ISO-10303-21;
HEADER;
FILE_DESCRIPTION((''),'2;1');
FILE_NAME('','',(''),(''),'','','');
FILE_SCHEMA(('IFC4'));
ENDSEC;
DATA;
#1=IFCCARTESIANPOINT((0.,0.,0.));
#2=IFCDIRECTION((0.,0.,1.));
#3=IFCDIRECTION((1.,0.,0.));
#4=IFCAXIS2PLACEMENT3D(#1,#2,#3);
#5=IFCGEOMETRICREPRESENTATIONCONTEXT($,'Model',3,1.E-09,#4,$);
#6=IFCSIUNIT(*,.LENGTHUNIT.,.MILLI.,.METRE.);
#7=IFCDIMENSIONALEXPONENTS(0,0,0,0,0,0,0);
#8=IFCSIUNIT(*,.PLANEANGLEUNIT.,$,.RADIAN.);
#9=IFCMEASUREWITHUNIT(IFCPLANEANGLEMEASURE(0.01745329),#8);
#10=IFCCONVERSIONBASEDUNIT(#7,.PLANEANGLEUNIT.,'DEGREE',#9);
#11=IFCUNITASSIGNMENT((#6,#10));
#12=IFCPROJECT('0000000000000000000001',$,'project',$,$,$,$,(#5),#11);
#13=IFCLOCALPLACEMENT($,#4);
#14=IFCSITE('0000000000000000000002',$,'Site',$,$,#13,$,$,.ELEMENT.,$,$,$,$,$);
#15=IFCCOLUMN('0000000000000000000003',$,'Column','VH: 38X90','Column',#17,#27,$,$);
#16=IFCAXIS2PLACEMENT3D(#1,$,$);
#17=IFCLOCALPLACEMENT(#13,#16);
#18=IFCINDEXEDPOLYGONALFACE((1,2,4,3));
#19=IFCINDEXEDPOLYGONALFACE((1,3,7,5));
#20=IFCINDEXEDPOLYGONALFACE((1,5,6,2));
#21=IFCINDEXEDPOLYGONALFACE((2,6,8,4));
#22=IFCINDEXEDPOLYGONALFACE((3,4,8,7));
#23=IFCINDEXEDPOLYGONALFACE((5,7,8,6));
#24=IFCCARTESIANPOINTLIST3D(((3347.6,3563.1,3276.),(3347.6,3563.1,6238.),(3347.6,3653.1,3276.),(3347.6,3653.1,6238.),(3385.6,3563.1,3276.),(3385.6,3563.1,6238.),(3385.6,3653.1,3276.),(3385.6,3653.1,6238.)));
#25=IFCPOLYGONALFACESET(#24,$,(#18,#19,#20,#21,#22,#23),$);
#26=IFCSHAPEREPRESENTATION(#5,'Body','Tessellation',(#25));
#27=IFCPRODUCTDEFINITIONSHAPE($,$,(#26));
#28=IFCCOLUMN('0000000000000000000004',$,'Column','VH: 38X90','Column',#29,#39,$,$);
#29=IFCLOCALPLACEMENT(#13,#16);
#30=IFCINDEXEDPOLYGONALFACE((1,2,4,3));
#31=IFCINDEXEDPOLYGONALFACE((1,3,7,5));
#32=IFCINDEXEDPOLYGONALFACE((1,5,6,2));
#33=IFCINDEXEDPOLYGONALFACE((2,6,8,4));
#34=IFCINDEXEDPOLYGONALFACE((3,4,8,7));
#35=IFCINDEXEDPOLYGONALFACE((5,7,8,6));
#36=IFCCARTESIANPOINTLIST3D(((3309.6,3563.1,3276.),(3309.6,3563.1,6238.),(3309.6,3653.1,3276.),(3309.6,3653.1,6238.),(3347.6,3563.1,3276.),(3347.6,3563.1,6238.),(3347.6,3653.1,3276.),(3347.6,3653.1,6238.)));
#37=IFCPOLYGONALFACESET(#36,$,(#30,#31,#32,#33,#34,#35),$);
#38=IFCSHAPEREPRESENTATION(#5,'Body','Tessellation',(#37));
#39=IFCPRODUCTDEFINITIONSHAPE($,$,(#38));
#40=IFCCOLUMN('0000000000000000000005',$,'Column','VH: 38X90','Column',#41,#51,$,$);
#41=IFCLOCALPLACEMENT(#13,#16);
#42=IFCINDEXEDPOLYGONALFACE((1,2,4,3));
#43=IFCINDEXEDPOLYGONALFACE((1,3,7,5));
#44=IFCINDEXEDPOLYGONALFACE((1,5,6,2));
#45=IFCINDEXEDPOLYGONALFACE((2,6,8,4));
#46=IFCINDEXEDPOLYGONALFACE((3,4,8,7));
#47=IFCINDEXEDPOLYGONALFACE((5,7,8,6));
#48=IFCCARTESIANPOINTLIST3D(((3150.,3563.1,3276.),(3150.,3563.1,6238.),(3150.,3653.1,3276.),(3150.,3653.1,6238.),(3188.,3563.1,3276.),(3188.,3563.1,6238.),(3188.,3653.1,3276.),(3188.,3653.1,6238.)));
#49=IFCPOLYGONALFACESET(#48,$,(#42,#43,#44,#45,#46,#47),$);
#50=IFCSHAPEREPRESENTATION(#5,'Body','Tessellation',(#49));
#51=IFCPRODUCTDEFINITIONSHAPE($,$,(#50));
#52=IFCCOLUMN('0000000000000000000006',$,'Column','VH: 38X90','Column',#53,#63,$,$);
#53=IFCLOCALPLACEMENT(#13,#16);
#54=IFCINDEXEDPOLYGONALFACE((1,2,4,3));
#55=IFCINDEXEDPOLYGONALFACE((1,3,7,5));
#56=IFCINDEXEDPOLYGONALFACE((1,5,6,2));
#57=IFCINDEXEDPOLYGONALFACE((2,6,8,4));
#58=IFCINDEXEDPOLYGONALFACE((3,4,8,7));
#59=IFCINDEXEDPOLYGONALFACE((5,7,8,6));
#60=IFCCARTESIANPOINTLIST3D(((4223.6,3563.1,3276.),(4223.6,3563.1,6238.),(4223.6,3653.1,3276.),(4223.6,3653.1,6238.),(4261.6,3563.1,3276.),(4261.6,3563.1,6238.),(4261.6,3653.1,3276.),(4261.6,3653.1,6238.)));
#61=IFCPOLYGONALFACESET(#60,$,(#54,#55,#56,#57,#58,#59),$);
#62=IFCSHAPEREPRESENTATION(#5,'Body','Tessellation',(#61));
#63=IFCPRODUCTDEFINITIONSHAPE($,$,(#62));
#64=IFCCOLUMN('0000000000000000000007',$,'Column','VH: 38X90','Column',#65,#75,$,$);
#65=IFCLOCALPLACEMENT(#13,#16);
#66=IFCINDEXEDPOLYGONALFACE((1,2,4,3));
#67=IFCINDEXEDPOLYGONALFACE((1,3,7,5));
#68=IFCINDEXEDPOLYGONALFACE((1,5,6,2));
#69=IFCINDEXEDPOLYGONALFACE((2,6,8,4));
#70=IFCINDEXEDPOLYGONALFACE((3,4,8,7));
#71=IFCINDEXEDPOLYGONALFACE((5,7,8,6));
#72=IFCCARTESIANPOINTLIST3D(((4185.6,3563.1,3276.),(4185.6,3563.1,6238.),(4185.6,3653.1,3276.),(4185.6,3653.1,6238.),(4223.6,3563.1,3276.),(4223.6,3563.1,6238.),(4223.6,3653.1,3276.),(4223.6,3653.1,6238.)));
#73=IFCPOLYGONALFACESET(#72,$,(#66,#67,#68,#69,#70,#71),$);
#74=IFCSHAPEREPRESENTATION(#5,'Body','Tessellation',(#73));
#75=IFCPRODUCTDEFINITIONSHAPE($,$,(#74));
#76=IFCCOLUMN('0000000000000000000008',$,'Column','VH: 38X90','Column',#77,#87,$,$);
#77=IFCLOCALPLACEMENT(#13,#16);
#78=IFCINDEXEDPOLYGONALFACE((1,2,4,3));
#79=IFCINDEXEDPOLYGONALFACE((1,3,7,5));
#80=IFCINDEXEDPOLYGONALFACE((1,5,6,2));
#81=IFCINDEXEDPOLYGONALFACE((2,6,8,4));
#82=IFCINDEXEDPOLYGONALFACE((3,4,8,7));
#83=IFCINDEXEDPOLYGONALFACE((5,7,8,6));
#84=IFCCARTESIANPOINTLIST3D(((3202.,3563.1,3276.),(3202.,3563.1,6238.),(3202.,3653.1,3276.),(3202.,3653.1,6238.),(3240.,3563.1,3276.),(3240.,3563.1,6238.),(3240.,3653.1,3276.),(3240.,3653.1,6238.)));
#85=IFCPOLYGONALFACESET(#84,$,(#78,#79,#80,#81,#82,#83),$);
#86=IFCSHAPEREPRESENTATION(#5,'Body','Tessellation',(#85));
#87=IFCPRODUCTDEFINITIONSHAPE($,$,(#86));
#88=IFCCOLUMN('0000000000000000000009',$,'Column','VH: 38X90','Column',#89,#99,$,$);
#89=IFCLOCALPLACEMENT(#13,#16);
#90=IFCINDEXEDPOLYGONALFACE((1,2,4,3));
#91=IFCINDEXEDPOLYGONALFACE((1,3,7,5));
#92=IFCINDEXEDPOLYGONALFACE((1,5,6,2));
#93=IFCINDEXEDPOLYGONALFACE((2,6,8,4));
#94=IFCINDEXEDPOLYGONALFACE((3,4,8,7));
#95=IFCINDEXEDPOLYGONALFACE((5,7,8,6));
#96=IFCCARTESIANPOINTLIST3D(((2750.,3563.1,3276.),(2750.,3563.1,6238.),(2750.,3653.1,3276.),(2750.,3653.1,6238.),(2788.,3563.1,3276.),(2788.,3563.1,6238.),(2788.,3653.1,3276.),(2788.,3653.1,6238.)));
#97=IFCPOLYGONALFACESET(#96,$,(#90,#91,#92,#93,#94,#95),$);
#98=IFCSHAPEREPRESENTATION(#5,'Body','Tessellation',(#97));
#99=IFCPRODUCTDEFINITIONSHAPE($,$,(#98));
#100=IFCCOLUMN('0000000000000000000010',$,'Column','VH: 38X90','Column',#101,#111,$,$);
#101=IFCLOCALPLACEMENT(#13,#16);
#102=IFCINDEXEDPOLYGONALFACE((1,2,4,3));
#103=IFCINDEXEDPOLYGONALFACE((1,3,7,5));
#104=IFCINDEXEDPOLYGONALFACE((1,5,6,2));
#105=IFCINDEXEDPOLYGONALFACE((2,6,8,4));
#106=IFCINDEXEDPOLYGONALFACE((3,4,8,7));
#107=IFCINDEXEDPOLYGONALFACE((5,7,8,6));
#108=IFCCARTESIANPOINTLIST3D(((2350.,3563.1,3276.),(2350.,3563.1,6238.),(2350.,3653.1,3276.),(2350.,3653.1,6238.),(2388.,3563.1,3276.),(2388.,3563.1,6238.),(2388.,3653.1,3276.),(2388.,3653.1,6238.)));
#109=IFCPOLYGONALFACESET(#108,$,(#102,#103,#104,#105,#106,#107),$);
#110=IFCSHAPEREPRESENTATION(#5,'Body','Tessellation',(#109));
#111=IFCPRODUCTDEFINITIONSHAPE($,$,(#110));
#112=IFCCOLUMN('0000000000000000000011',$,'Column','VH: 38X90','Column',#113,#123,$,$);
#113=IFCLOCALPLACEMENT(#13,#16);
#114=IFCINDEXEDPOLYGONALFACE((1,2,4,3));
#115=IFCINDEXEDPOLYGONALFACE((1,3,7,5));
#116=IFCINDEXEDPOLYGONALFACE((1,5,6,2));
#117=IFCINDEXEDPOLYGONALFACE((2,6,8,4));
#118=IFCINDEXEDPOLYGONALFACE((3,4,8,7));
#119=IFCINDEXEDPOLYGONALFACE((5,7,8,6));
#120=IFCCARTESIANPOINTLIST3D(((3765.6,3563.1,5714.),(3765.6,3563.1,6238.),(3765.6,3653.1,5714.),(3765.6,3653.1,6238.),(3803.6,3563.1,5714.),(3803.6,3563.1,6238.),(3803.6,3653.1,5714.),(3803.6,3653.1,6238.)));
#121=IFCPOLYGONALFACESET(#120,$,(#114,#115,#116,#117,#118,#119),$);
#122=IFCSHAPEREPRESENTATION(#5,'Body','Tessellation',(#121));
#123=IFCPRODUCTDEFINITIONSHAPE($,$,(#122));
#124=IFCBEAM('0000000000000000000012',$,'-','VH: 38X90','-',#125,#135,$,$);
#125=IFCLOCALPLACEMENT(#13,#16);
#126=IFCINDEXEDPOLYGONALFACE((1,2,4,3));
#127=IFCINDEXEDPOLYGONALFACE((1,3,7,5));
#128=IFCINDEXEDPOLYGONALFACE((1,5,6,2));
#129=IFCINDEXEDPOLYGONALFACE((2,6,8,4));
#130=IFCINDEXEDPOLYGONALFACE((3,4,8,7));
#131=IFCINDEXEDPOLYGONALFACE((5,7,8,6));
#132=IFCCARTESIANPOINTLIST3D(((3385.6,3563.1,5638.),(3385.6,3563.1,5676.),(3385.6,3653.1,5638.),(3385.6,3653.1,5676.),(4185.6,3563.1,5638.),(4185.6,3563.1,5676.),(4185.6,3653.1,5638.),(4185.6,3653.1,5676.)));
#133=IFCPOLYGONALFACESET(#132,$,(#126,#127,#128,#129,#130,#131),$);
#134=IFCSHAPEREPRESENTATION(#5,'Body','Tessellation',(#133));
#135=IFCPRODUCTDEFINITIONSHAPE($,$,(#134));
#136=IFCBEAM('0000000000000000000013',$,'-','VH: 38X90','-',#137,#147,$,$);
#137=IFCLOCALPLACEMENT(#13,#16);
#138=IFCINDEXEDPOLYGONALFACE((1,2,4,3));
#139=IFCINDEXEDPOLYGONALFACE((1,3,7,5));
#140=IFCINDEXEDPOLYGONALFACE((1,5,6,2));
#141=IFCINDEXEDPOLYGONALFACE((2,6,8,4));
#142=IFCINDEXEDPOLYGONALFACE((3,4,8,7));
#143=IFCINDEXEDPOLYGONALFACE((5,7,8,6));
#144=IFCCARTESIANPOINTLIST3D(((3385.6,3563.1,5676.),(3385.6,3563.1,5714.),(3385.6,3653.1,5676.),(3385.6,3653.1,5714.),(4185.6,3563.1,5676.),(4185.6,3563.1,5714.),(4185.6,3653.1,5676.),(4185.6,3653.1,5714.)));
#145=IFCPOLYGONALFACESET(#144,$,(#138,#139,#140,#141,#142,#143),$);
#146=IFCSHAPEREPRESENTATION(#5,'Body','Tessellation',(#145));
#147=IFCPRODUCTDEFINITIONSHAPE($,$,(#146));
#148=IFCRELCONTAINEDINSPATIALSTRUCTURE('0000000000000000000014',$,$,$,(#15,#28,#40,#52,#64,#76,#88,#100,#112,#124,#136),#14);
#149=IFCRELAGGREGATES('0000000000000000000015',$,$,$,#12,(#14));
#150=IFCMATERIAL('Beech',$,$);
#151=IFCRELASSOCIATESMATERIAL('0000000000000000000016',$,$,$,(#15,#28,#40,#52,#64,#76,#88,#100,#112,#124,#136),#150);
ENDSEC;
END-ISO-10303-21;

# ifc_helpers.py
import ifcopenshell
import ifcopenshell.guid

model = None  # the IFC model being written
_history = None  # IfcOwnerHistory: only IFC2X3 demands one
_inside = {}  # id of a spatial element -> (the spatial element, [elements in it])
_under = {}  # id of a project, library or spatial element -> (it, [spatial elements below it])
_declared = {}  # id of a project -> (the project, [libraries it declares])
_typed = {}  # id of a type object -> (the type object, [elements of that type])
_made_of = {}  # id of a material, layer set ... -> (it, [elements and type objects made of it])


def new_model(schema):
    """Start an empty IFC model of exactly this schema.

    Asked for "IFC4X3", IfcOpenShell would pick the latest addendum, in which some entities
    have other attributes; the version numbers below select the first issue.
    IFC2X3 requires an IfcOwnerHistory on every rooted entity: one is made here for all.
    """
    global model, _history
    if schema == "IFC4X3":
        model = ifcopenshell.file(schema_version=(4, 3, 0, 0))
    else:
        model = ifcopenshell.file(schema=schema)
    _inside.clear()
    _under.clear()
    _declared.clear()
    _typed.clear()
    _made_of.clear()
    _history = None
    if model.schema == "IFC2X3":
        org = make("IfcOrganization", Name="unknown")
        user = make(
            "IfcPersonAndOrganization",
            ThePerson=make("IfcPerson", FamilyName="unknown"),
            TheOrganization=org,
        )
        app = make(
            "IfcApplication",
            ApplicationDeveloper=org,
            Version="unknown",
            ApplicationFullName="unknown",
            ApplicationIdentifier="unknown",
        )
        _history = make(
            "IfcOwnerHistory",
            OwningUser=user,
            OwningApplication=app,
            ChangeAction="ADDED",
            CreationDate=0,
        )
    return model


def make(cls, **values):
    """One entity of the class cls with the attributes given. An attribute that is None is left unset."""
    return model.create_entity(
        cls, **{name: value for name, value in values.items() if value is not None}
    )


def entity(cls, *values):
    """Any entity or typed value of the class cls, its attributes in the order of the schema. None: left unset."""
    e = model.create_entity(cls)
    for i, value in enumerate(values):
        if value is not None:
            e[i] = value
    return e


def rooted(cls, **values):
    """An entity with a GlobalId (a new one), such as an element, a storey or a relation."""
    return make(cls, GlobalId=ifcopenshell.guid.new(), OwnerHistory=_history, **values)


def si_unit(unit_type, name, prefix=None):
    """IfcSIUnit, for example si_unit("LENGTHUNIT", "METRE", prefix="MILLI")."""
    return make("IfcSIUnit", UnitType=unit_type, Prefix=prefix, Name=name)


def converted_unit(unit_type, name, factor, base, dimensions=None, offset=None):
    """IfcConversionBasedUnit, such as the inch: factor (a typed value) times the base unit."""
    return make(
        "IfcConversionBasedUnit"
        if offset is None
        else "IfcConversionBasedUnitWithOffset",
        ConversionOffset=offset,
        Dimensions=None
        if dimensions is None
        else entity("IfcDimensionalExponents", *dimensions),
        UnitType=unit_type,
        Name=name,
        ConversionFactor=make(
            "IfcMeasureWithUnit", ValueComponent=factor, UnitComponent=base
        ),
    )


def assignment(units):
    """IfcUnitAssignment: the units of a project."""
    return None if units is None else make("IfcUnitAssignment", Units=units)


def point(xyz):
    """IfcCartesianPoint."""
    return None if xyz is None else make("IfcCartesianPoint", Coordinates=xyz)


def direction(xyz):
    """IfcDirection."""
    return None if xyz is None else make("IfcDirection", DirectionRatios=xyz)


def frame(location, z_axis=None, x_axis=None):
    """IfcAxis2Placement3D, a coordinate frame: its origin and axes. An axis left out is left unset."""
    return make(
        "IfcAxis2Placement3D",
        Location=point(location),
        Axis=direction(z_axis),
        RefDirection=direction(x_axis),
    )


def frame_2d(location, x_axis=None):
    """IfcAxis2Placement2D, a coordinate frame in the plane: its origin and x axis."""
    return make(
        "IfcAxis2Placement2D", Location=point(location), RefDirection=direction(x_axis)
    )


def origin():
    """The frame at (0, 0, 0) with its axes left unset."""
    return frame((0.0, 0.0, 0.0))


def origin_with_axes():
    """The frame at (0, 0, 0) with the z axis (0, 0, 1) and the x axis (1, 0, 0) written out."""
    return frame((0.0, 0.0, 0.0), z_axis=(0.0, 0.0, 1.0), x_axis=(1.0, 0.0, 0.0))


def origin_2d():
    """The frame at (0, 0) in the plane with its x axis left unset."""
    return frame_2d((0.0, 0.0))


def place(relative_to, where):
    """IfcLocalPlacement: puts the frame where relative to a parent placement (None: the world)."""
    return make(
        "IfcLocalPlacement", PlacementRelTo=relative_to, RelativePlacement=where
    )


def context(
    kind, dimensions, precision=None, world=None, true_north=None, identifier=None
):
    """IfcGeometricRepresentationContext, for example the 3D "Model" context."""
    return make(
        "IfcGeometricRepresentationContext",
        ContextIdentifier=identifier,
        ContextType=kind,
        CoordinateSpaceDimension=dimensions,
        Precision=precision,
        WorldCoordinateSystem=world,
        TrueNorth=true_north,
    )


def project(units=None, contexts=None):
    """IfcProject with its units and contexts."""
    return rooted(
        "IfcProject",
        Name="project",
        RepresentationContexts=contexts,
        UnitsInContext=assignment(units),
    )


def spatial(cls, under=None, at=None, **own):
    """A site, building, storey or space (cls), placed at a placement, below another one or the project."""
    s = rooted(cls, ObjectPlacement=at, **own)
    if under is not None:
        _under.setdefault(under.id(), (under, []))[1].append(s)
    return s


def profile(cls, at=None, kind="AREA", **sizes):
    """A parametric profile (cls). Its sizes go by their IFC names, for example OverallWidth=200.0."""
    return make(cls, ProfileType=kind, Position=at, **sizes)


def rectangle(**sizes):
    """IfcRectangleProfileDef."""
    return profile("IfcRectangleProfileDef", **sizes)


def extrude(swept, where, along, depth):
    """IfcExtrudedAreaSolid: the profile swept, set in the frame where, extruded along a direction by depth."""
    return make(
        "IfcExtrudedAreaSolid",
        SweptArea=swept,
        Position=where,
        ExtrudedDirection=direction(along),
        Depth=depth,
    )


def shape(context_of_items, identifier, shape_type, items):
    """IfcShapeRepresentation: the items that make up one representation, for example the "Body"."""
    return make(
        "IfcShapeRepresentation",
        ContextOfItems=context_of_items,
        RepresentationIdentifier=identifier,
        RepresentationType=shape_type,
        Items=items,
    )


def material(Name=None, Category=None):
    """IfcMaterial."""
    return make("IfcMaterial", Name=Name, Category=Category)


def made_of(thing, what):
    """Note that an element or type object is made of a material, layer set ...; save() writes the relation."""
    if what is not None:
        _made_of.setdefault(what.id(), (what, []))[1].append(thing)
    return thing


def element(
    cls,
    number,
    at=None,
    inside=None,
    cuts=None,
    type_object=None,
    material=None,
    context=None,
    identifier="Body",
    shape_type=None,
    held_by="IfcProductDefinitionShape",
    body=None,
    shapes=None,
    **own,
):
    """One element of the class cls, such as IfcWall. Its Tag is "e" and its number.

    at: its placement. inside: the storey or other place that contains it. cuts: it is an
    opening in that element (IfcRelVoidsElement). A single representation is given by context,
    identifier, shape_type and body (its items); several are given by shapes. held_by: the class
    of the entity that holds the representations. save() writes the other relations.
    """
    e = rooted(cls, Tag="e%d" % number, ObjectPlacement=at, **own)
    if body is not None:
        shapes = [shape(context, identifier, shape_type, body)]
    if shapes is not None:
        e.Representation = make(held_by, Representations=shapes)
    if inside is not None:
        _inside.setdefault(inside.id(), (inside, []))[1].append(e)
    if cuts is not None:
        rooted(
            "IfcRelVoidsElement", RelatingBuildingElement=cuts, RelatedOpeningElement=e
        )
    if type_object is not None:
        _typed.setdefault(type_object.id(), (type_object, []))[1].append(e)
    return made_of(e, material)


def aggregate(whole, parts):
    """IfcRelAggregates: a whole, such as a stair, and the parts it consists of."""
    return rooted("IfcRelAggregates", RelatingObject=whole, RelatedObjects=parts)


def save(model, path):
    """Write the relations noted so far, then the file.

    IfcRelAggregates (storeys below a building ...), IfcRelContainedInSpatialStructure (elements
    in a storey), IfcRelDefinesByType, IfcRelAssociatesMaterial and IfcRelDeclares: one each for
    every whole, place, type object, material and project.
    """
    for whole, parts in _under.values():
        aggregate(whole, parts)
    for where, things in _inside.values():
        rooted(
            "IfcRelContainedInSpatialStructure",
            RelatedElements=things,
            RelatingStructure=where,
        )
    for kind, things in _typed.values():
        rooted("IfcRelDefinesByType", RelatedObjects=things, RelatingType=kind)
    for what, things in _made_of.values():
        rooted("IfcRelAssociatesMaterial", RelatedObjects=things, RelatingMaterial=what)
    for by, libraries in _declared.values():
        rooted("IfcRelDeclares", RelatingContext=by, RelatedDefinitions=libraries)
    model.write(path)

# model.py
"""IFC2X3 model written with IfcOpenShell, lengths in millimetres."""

from ifc_helpers import new_model, entity, si_unit, converted_unit, frame, origin, origin_with_axes, origin_2d, place, context, project, spatial, rectangle, extrude, material, element, save


model = new_model("IFC2X3")

# Units and contexts
model_context = context("Model", 3, precision=1e-09, world=origin_with_axes())
ifc_project = project(units=[si_unit("LENGTHUNIT", "METRE", prefix="MILLI"), converted_unit("PLANEANGLEUNIT", "DEGREE", entity("IfcPlaneAngleMeasure", 0.01745329), si_unit("PLANEANGLEUNIT", "RADIAN"), dimensions=[0, 0, 0, 0, 0, 0, 0])], contexts=[model_context])

# Site
site_placement = place(None, origin_with_axes())
site = spatial("IfcSite", under=ifc_project, at=site_placement, Name="Site", CompositionType="ELEMENT")

# Columns
ifc_material = material(Name="Beech")
for number, where, z_axis, x_axis, name in (
    (1, (3366.6, 3608.1, 3276.0), (0.0, 0.0, -1.0), (-1.0, 0.0, 0.0), "Column"),
    (2, (3328.6, 3608.1, 3276.0), (0.0, 0.0, -1.0), (-1.0, 0.0, 0.0), "Column"),
    (3, (3169.0, 3608.1, 3276.0), (0.0, 0.0, -1.0), (-1.0, 0.0, 0.0), "Column"),
    (4, (4242.6, 3608.1, 3276.0), (0.0, 0.0, -1.0), (-1.0, 0.0, 0.0), "Column"),
    (5, (4204.6, 3608.1, 3276.0), (0.0, 0.0, -1.0), (-1.0, 0.0, 0.0), "Column"),
    (6, (3221.0, 3608.1, 3276.0), (0.0, 0.0, -1.0), (-1.0, 0.0, 0.0), "Column"),
    (7, (2769.0, 3608.1, 3276.0), (0.0, 0.0, -1.0), (-1.0, 0.0, 0.0), "Column"),
    (8, (2369.0, 3608.1, 3276.0), (0.0, 0.0, -1.0), (-1.0, 0.0, 0.0), "Column"),
):
    element("IfcColumn", number, at=place(None, frame(where, z_axis=z_axis, x_axis=x_axis)), inside=site, material=ifc_material, Name=name, Description="VH: 38X90", ObjectType="Column", context=model_context, shape_type="SweptSolid", body=[
        extrude(rectangle(XDim=38.0, YDim=90.0, at=origin_2d()), origin(), (0.0, 0.0, -1.0), 2962.0),
    ])
column_placement = place(None, frame((3784.6, 3608.1, 5714.0), z_axis=(0.0, 0.0, -1.0), x_axis=(-1.0, 0.0, 0.0)))
element("IfcColumn", 9, at=column_placement, inside=site, material=ifc_material, Name="Column", Description="VH: 38X90", ObjectType="Column", context=model_context, shape_type="SweptSolid", body=[
    extrude(rectangle(XDim=38.0, YDim=90.0, at=origin_2d()), origin(), (0.0, 0.0, -1.0), 524.0),
])

# Beams
for number, where, z_axis, x_axis, name in (
    (10, (3385.6, 3608.1, 5657.0), (-1.0, 0.0, 0.0), (0.0, 0.0, -1.0), "-"),
    (11, (3385.6, 3608.1, 5695.0), (-1.0, 0.0, 0.0), (0.0, 0.0, -1.0), "-"),
):
    element("IfcBeam", number, at=place(None, frame(where, z_axis=z_axis, x_axis=x_axis)), inside=site, material=ifc_material, Name=name, Description="VH: 38X90", ObjectType="-", context=model_context, shape_type="SweptSolid", body=[
        extrude(rectangle(XDim=38.0, YDim=90.0, at=origin_2d()), origin(), (0.0, 0.0, -1.0), 800.0),
    ])

save(model, "model.ifc")
